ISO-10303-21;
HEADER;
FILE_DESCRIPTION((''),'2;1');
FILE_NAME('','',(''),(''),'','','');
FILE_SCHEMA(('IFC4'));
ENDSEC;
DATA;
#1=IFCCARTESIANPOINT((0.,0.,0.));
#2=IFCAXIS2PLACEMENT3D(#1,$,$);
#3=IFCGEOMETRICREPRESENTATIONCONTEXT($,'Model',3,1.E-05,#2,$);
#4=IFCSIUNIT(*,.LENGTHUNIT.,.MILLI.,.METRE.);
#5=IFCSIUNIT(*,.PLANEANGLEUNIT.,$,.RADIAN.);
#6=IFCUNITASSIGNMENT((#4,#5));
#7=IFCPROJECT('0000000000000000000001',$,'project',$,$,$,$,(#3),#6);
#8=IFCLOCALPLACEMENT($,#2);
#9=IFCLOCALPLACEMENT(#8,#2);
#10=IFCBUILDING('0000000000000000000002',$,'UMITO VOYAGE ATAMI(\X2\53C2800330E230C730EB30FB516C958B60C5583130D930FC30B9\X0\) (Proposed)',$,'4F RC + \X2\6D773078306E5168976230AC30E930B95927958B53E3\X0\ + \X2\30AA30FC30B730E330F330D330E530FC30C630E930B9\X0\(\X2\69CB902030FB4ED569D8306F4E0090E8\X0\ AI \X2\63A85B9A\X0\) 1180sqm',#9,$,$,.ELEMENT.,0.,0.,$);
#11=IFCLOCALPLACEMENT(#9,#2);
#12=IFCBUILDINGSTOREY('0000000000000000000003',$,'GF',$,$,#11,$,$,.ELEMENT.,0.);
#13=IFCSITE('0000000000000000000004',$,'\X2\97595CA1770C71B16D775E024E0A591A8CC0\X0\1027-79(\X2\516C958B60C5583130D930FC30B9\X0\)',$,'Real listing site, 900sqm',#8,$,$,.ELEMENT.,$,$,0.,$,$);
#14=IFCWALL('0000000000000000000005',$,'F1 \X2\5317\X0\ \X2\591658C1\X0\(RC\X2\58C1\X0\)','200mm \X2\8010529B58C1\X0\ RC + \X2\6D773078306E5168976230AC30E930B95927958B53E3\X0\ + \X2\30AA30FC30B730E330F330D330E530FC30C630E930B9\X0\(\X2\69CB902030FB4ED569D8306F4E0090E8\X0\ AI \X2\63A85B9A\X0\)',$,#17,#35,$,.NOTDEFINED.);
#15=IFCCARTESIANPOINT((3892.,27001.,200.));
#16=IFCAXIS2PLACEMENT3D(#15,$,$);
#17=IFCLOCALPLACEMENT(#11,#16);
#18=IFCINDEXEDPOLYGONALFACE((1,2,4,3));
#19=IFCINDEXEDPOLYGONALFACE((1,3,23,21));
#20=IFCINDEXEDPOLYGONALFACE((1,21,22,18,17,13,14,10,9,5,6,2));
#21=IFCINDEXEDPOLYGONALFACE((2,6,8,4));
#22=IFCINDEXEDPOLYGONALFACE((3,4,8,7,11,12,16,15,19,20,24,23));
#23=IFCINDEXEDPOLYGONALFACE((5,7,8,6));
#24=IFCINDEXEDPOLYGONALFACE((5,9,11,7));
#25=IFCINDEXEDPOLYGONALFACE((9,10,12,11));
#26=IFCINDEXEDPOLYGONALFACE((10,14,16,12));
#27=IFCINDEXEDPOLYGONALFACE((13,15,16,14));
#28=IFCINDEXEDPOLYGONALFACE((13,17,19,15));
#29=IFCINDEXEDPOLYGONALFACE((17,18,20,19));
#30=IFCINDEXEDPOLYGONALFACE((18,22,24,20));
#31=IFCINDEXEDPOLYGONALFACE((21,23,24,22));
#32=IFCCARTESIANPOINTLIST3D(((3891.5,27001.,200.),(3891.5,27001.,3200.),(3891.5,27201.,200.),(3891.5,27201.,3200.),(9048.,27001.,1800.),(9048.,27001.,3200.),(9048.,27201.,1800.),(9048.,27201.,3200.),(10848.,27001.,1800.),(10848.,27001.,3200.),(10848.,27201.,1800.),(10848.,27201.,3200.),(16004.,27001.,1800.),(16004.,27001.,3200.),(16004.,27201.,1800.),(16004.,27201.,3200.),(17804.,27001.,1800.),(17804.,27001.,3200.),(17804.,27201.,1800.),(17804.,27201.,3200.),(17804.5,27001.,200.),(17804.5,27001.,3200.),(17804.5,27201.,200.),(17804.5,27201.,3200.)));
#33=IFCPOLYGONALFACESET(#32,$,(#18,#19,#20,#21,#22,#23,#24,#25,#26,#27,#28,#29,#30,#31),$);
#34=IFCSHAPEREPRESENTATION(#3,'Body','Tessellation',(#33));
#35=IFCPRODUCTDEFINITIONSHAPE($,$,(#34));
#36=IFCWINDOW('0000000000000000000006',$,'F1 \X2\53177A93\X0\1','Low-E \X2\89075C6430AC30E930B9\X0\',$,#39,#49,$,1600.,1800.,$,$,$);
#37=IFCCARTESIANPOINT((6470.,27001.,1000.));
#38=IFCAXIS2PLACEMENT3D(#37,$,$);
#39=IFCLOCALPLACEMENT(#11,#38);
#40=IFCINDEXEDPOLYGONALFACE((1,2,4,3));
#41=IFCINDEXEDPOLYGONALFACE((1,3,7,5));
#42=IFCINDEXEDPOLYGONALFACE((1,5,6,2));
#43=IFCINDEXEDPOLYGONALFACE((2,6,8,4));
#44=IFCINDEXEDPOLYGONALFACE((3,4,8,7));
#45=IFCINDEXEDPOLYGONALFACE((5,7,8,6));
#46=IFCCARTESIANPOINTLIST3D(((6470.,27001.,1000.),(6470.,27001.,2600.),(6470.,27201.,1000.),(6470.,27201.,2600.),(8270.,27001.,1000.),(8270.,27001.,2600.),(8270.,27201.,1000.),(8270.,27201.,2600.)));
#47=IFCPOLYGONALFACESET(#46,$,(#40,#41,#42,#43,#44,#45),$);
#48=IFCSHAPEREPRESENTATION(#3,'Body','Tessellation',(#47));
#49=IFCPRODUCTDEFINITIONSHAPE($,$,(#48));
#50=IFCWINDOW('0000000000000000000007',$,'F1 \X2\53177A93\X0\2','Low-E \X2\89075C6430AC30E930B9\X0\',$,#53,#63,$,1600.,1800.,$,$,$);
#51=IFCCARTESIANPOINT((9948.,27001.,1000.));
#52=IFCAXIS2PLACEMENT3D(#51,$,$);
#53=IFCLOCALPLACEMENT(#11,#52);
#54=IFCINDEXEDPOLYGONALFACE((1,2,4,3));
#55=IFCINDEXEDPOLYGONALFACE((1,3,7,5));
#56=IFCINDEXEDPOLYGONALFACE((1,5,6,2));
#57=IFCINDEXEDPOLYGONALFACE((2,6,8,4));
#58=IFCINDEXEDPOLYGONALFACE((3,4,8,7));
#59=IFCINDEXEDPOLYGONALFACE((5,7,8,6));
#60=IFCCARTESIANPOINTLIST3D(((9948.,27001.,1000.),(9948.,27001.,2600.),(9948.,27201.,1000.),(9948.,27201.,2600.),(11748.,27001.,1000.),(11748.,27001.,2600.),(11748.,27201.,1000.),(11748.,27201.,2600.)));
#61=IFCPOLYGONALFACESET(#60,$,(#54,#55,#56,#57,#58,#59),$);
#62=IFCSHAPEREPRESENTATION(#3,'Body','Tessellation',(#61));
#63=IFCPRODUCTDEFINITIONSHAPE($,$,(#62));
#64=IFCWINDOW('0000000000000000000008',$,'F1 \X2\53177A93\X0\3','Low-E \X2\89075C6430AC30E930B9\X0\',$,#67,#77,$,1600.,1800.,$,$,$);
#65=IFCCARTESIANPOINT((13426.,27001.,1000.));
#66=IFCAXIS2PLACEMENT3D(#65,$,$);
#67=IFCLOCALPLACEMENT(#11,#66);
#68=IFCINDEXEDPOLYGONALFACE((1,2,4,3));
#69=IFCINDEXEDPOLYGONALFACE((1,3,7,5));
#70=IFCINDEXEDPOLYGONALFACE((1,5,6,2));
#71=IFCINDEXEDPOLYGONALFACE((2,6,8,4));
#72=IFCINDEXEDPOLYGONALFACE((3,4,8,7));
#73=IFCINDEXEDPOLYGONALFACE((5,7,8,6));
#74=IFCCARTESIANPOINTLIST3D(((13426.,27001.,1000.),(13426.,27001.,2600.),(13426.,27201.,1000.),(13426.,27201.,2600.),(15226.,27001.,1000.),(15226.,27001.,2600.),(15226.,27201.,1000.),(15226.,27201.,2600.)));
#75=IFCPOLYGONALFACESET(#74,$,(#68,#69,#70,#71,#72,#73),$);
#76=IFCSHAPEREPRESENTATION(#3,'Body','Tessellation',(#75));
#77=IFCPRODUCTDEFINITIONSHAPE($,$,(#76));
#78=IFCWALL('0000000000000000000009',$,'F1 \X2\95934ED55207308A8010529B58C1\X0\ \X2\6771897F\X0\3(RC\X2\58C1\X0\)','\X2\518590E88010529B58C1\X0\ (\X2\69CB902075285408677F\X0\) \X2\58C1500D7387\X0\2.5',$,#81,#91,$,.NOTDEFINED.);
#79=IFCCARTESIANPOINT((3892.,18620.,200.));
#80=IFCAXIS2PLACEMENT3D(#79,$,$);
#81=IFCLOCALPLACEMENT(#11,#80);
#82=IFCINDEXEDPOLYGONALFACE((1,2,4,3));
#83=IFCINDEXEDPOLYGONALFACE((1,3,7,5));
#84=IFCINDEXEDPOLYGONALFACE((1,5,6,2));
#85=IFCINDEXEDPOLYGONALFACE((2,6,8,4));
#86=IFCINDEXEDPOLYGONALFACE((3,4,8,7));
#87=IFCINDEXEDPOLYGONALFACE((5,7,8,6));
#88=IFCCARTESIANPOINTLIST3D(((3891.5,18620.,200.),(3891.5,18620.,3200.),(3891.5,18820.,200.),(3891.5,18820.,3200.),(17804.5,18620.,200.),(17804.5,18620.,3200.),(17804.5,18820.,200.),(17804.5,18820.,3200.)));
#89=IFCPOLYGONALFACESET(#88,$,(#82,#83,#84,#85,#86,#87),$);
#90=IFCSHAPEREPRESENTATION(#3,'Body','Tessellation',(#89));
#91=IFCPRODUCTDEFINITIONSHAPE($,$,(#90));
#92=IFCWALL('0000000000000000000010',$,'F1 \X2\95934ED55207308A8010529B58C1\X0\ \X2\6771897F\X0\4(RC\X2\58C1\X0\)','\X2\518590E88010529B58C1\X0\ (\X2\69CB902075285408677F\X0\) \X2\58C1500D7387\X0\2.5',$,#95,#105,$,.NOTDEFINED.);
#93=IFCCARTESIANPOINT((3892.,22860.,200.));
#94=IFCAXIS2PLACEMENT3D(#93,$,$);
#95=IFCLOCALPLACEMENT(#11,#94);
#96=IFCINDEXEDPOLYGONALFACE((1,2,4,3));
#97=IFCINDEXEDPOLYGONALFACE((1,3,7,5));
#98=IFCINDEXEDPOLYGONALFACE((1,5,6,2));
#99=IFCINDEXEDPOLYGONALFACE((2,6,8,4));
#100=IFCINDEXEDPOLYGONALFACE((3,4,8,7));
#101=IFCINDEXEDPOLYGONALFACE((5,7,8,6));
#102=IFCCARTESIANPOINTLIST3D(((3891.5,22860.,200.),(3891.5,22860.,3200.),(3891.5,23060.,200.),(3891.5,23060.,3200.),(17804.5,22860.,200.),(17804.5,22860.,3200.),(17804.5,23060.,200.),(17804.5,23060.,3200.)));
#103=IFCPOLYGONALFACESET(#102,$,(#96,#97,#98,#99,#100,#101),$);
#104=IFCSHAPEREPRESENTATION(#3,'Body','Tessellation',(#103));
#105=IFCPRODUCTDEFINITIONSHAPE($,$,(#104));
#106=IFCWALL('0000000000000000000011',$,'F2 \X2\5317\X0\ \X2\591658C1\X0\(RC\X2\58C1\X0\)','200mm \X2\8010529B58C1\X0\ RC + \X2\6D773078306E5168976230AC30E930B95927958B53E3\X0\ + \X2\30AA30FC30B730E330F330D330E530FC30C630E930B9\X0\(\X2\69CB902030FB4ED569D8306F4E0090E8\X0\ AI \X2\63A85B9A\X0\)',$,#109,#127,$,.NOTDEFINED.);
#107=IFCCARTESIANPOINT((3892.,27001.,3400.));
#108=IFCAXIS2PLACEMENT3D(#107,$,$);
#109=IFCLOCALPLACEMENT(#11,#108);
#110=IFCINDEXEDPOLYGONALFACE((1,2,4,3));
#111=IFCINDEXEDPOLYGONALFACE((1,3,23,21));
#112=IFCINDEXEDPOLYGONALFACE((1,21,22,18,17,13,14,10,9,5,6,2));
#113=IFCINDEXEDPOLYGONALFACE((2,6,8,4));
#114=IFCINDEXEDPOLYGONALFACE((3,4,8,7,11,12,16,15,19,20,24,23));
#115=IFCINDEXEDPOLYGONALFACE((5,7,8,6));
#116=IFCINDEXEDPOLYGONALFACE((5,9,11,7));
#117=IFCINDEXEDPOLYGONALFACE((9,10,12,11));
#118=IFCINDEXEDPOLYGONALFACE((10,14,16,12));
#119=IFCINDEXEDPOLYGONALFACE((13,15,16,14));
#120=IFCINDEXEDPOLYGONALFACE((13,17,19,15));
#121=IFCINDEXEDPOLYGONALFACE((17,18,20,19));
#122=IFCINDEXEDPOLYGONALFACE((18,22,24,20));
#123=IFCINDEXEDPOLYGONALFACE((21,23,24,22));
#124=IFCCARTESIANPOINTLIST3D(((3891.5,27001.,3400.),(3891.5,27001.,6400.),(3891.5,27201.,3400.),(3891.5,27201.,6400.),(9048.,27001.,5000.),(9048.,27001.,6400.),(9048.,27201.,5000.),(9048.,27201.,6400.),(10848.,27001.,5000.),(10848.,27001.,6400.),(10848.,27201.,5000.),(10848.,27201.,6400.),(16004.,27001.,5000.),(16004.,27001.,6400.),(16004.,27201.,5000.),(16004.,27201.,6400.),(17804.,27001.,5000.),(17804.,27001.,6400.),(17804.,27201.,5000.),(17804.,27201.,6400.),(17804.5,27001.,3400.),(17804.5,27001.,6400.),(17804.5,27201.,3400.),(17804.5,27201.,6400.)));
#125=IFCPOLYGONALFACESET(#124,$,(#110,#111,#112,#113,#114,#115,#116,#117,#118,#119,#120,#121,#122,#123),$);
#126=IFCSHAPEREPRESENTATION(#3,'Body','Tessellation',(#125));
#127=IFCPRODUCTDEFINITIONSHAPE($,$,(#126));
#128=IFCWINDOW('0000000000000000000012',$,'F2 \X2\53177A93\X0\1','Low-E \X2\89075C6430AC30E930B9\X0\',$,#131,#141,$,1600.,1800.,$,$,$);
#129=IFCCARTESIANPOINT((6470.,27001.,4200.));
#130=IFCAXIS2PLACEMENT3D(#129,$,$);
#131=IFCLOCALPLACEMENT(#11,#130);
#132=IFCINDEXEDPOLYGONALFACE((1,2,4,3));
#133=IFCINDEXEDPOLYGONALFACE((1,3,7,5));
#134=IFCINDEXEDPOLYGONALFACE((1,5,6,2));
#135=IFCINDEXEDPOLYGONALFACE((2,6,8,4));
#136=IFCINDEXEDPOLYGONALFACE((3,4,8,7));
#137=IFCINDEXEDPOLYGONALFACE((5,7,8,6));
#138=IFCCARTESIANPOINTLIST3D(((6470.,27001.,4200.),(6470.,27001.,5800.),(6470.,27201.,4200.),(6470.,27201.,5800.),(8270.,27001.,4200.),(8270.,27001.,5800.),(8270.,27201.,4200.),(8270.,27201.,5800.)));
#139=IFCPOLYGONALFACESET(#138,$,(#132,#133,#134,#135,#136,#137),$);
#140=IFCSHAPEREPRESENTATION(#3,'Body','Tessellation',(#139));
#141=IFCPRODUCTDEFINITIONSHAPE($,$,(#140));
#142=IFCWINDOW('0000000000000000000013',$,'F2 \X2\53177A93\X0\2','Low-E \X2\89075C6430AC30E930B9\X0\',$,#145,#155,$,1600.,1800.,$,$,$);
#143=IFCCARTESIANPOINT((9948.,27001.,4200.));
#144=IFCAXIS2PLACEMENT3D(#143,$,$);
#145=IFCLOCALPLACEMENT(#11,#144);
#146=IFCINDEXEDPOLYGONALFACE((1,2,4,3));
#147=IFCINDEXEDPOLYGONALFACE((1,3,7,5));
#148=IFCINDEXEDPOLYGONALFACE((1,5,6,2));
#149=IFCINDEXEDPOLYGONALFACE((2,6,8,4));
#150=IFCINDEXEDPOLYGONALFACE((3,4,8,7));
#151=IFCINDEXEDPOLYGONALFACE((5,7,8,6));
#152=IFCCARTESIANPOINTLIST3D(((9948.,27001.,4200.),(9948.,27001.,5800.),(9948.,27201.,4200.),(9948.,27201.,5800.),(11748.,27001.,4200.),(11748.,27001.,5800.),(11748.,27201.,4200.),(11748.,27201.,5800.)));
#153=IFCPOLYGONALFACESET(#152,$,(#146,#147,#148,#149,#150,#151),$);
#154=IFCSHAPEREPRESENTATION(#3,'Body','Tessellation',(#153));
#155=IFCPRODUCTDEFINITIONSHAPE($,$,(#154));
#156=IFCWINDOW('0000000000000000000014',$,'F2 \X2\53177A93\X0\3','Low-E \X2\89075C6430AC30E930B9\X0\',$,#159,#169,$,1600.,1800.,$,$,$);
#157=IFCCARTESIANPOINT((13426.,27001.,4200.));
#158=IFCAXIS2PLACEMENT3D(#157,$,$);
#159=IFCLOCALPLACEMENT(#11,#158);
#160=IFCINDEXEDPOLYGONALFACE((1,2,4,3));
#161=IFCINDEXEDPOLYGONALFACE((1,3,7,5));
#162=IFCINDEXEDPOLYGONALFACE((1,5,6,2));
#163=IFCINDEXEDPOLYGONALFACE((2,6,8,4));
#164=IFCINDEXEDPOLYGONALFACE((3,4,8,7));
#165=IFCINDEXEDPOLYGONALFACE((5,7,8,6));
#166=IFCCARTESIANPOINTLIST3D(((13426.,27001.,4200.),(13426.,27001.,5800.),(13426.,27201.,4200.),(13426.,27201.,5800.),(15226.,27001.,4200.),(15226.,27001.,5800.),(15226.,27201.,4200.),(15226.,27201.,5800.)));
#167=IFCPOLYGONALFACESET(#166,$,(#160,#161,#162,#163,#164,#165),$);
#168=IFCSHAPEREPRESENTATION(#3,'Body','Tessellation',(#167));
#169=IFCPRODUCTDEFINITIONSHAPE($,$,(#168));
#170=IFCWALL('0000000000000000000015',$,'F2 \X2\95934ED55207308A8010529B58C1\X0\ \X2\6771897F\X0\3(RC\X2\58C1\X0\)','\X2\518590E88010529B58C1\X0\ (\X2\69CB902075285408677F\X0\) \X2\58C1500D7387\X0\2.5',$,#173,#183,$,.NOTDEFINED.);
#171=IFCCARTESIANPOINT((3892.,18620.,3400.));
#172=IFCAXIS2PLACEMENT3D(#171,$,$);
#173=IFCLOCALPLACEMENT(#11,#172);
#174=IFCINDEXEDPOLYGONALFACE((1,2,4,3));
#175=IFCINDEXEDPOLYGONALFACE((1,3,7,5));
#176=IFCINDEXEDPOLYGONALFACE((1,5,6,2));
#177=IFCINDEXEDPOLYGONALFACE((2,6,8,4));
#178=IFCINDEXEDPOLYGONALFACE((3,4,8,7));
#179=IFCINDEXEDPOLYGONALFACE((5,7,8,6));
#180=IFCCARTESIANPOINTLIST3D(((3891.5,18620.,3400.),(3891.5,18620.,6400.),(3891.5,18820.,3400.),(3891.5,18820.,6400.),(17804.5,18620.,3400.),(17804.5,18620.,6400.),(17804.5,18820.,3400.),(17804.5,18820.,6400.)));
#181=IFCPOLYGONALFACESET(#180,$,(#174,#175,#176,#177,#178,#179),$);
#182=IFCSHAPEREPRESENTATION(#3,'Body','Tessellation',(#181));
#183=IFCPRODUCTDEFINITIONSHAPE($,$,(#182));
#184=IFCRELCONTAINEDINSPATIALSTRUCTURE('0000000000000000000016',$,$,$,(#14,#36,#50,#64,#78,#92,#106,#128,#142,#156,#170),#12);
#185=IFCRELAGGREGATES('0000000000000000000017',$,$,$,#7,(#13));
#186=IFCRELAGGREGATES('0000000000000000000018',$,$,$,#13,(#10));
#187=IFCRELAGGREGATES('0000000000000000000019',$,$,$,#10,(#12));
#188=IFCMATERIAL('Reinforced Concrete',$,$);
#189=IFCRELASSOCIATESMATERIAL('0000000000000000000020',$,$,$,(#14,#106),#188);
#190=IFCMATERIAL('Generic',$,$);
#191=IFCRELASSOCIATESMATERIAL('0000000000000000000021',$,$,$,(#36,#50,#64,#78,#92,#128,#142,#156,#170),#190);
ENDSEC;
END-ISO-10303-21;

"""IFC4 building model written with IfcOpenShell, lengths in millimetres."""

from ifc_helpers import new_model, si_unit, frame, frame_2d, origin, place, context, project, spatial, rectangle, extrude, material, element, fill, save


model = new_model("IFC4")

# Units and contexts
model_context = context("Model", 3, precision=1e-05, world=origin())
ifc_project = project(units=[si_unit("LENGTHUNIT", "METRE", prefix="MILLI"), si_unit("PLANEANGLEUNIT", "RADIAN")], contexts=[model_context])

# Site, building, storey
site_placement = place(None, origin())
site = spatial("IfcSite", under=ifc_project, at=site_placement, Name="静岡県熱海市上多賀1027-79(公開情報ベース)", ObjectType="Real listing site, 900sqm", CompositionType="ELEMENT", RefElevation=0.0)
building_placement = place(site_placement, origin())
building = spatial("IfcBuilding", under=site, at=building_placement, Name="UMITO VOYAGE ATAMI(参考モデル・公開情報ベース) (Proposed)", ObjectType="4F RC + 海への全面ガラス大開口 + オーシャンビューテラス(構造・仕様は一部 AI 推定) 1180sqm", CompositionType="ELEMENT", ElevationOfRefHeight=0.0, ElevationOfTerrain=0.0)
storey_placement = place(building_placement, origin())
storey = spatial("IfcBuildingStorey", under=building, at=storey_placement, Name="GF", CompositionType="ELEMENT", Elevation=0.0)

# Wall, openings, windows
ifc_material_1 = material(Name="Reinforced Concrete")
wall_1_placement = place(storey_placement, frame((3892.0, 27001.0, 200.0)))
wall_1 = element("IfcWall", 1, at=wall_1_placement, inside=storey, material=ifc_material_1, Name="F1 北 外壁(RC壁)", Description="200mm 耐力壁 RC + 海への全面ガラス大開口 + オーシャンビューテラス(構造・仕様は一部 AI 推定)", PredefinedType="NOTDEFINED", context=model_context, shape_type="SweptSolid", body=[
    extrude(rectangle(XDim=13913.0, YDim=200.0, at=frame_2d((6956.0, 100.0))), frame((3892.0, 27001.0, 200.0)), (0.0, 0.0, 1.0), 3000.0),
])
opening_1_placement = place(storey_placement, frame((6470.0, 27001.0, 1000.0)))
opening_1 = element("IfcOpeningElement", 2, at=opening_1_placement, cuts=wall_1, PredefinedType="NOTDEFINED", context=model_context, shape_type="SweptSolid", body=[
    extrude(rectangle(XDim=1800.0, YDim=200.0, at=frame_2d((900.0, 100.0))), frame((6470.0, 27001.0, 1000.0)), (0.0, 0.0, 1.0), 1600.0),
])
opening_2_placement = place(storey_placement, frame((9948.0, 27001.0, 1000.0)))
opening_2 = element("IfcOpeningElement", 3, at=opening_2_placement, cuts=wall_1, PredefinedType="NOTDEFINED", context=model_context, shape_type="SweptSolid", body=[
    extrude(rectangle(XDim=1800.0, YDim=200.0, at=frame_2d((900.0, 100.0))), frame((9948.0, 27001.0, 1000.0)), (0.0, 0.0, 1.0), 1600.0),
])
opening_3_placement = place(storey_placement, frame((13426.0, 27001.0, 1000.0)))
opening_3 = element("IfcOpeningElement", 4, at=opening_3_placement, cuts=wall_1, PredefinedType="NOTDEFINED", context=model_context, shape_type="SweptSolid", body=[
    extrude(rectangle(XDim=1800.0, YDim=200.0, at=frame_2d((900.0, 100.0))), frame((13426.0, 27001.0, 1000.0)), (0.0, 0.0, 1.0), 1600.0),
])
ifc_material_2 = material(Name="Generic")
window_1_placement = place(storey_placement, frame((6470.0, 27001.0, 1000.0)))
window_1 = element("IfcWindow", 5, at=window_1_placement, inside=storey, material=ifc_material_2, Name="F1 北窓1", Description="Low-E 複層ガラス", OverallHeight=1600.0, OverallWidth=1800.0, context=model_context, shape_type="SweptSolid", body=[
    extrude(rectangle(XDim=1800.0, YDim=200.0, at=frame_2d((900.0, 100.0))), frame((6470.0, 27001.0, 1000.0)), (0.0, 0.0, 1.0), 1600.0),
])
fill(opening_1, window_1)
window_2_placement = place(storey_placement, frame((9948.0, 27001.0, 1000.0)))
window_2 = element("IfcWindow", 6, at=window_2_placement, inside=storey, material=ifc_material_2, Name="F1 北窓2", Description="Low-E 複層ガラス", OverallHeight=1600.0, OverallWidth=1800.0, context=model_context, shape_type="SweptSolid", body=[
    extrude(rectangle(XDim=1800.0, YDim=200.0, at=frame_2d((900.0, 100.0))), frame((9948.0, 27001.0, 1000.0)), (0.0, 0.0, 1.0), 1600.0),
])
fill(opening_2, window_2)
window_3_placement = place(storey_placement, frame((13426.0, 27001.0, 1000.0)))
window_3 = element("IfcWindow", 7, at=window_3_placement, inside=storey, material=ifc_material_2, Name="F1 北窓3", Description="Low-E 複層ガラス", OverallHeight=1600.0, OverallWidth=1800.0, context=model_context, shape_type="SweptSolid", body=[
    extrude(rectangle(XDim=1800.0, YDim=200.0, at=frame_2d((900.0, 100.0))), frame((13426.0, 27001.0, 1000.0)), (0.0, 0.0, 1.0), 1600.0),
])
fill(opening_3, window_3)

# Walls
wall_2_placement = place(storey_placement, frame((3892.0, 18620.0, 200.0)))
element("IfcWall", 8, at=wall_2_placement, inside=storey, material=ifc_material_2, Name="F1 間仕切り耐力壁 東西3(RC壁)", Description="内部耐力壁 (構造用合板) 壁倍率2.5", PredefinedType="NOTDEFINED", context=model_context, shape_type="SweptSolid", body=[
    extrude(rectangle(XDim=13913.0, YDim=200.0, at=frame_2d((6956.0, 100.0))), frame((3892.0, 18620.0, 200.0)), (0.0, 0.0, 1.0), 3000.0),
])
wall_3_placement = place(storey_placement, frame((3892.0, 22860.0, 200.0)))
element("IfcWall", 9, at=wall_3_placement, inside=storey, material=ifc_material_2, Name="F1 間仕切り耐力壁 東西4(RC壁)", Description="内部耐力壁 (構造用合板) 壁倍率2.5", PredefinedType="NOTDEFINED", context=model_context, shape_type="SweptSolid", body=[
    extrude(rectangle(XDim=13913.0, YDim=200.0, at=frame_2d((6956.0, 100.0))), frame((3892.0, 22860.0, 200.0)), (0.0, 0.0, 1.0), 3000.0),
])

# Wall, openings, windows
wall_4_placement = place(storey_placement, frame((3892.0, 27001.0, 3400.0)))
wall_4 = element("IfcWall", 10, at=wall_4_placement, inside=storey, material=ifc_material_1, Name="F2 北 外壁(RC壁)", Description="200mm 耐力壁 RC + 海への全面ガラス大開口 + オーシャンビューテラス(構造・仕様は一部 AI 推定)", PredefinedType="NOTDEFINED", context=model_context, shape_type="SweptSolid", body=[
    extrude(rectangle(XDim=13913.0, YDim=200.0, at=frame_2d((6956.0, 100.0))), frame((3892.0, 27001.0, 3400.0)), (0.0, 0.0, 1.0), 3000.0),
])
opening_4_placement = place(storey_placement, frame((6470.0, 27001.0, 4200.0)))
opening_4 = element("IfcOpeningElement", 11, at=opening_4_placement, cuts=wall_4, PredefinedType="NOTDEFINED", context=model_context, shape_type="SweptSolid", body=[
    extrude(rectangle(XDim=1800.0, YDim=200.0, at=frame_2d((900.0, 100.0))), frame((6470.0, 27001.0, 4200.0)), (0.0, 0.0, 1.0), 1600.0),
])
opening_5_placement = place(storey_placement, frame((9948.0, 27001.0, 4200.0)))
opening_5 = element("IfcOpeningElement", 12, at=opening_5_placement, cuts=wall_4, PredefinedType="NOTDEFINED", context=model_context, shape_type="SweptSolid", body=[
    extrude(rectangle(XDim=1800.0, YDim=200.0, at=frame_2d((900.0, 100.0))), frame((9948.0, 27001.0, 4200.0)), (0.0, 0.0, 1.0), 1600.0),
])
opening_6_placement = place(storey_placement, frame((13426.0, 27001.0, 4200.0)))
opening_6 = element("IfcOpeningElement", 13, at=opening_6_placement, cuts=wall_4, PredefinedType="NOTDEFINED", context=model_context, shape_type="SweptSolid", body=[
    extrude(rectangle(XDim=1800.0, YDim=200.0, at=frame_2d((900.0, 100.0))), frame((13426.0, 27001.0, 4200.0)), (0.0, 0.0, 1.0), 1600.0),
])
window_4_placement = place(storey_placement, frame((6470.0, 27001.0, 4200.0)))
window_4 = element("IfcWindow", 14, at=window_4_placement, inside=storey, material=ifc_material_2, Name="F2 北窓1", Description="Low-E 複層ガラス", OverallHeight=1600.0, OverallWidth=1800.0, context=model_context, shape_type="SweptSolid", body=[
    extrude(rectangle(XDim=1800.0, YDim=200.0, at=frame_2d((900.0, 100.0))), frame((6470.0, 27001.0, 4200.0)), (0.0, 0.0, 1.0), 1600.0),
])
fill(opening_4, window_4)
window_5_placement = place(storey_placement, frame((9948.0, 27001.0, 4200.0)))
window_5 = element("IfcWindow", 15, at=window_5_placement, inside=storey, material=ifc_material_2, Name="F2 北窓2", Description="Low-E 複層ガラス", OverallHeight=1600.0, OverallWidth=1800.0, context=model_context, shape_type="SweptSolid", body=[
    extrude(rectangle(XDim=1800.0, YDim=200.0, at=frame_2d((900.0, 100.0))), frame((9948.0, 27001.0, 4200.0)), (0.0, 0.0, 1.0), 1600.0),
])
fill(opening_5, window_5)
window_6_placement = place(storey_placement, frame((13426.0, 27001.0, 4200.0)))
window_6 = element("IfcWindow", 16, at=window_6_placement, inside=storey, material=ifc_material_2, Name="F2 北窓3", Description="Low-E 複層ガラス", OverallHeight=1600.0, OverallWidth=1800.0, context=model_context, shape_type="SweptSolid", body=[
    extrude(rectangle(XDim=1800.0, YDim=200.0, at=frame_2d((900.0, 100.0))), frame((13426.0, 27001.0, 4200.0)), (0.0, 0.0, 1.0), 1600.0),
])
fill(opening_6, window_6)

# Wall
wall_5_placement = place(storey_placement, frame((3892.0, 18620.0, 3400.0)))
element("IfcWall", 17, at=wall_5_placement, inside=storey, material=ifc_material_2, Name="F2 間仕切り耐力壁 東西3(RC壁)", Description="内部耐力壁 (構造用合板) 壁倍率2.5", PredefinedType="NOTDEFINED", context=model_context, shape_type="SweptSolid", body=[
    extrude(rectangle(XDim=13913.0, YDim=200.0, at=frame_2d((6956.0, 100.0))), frame((3892.0, 18620.0, 3400.0)), (0.0, 0.0, 1.0), 3000.0),
])

save(model, "model.ifc")
